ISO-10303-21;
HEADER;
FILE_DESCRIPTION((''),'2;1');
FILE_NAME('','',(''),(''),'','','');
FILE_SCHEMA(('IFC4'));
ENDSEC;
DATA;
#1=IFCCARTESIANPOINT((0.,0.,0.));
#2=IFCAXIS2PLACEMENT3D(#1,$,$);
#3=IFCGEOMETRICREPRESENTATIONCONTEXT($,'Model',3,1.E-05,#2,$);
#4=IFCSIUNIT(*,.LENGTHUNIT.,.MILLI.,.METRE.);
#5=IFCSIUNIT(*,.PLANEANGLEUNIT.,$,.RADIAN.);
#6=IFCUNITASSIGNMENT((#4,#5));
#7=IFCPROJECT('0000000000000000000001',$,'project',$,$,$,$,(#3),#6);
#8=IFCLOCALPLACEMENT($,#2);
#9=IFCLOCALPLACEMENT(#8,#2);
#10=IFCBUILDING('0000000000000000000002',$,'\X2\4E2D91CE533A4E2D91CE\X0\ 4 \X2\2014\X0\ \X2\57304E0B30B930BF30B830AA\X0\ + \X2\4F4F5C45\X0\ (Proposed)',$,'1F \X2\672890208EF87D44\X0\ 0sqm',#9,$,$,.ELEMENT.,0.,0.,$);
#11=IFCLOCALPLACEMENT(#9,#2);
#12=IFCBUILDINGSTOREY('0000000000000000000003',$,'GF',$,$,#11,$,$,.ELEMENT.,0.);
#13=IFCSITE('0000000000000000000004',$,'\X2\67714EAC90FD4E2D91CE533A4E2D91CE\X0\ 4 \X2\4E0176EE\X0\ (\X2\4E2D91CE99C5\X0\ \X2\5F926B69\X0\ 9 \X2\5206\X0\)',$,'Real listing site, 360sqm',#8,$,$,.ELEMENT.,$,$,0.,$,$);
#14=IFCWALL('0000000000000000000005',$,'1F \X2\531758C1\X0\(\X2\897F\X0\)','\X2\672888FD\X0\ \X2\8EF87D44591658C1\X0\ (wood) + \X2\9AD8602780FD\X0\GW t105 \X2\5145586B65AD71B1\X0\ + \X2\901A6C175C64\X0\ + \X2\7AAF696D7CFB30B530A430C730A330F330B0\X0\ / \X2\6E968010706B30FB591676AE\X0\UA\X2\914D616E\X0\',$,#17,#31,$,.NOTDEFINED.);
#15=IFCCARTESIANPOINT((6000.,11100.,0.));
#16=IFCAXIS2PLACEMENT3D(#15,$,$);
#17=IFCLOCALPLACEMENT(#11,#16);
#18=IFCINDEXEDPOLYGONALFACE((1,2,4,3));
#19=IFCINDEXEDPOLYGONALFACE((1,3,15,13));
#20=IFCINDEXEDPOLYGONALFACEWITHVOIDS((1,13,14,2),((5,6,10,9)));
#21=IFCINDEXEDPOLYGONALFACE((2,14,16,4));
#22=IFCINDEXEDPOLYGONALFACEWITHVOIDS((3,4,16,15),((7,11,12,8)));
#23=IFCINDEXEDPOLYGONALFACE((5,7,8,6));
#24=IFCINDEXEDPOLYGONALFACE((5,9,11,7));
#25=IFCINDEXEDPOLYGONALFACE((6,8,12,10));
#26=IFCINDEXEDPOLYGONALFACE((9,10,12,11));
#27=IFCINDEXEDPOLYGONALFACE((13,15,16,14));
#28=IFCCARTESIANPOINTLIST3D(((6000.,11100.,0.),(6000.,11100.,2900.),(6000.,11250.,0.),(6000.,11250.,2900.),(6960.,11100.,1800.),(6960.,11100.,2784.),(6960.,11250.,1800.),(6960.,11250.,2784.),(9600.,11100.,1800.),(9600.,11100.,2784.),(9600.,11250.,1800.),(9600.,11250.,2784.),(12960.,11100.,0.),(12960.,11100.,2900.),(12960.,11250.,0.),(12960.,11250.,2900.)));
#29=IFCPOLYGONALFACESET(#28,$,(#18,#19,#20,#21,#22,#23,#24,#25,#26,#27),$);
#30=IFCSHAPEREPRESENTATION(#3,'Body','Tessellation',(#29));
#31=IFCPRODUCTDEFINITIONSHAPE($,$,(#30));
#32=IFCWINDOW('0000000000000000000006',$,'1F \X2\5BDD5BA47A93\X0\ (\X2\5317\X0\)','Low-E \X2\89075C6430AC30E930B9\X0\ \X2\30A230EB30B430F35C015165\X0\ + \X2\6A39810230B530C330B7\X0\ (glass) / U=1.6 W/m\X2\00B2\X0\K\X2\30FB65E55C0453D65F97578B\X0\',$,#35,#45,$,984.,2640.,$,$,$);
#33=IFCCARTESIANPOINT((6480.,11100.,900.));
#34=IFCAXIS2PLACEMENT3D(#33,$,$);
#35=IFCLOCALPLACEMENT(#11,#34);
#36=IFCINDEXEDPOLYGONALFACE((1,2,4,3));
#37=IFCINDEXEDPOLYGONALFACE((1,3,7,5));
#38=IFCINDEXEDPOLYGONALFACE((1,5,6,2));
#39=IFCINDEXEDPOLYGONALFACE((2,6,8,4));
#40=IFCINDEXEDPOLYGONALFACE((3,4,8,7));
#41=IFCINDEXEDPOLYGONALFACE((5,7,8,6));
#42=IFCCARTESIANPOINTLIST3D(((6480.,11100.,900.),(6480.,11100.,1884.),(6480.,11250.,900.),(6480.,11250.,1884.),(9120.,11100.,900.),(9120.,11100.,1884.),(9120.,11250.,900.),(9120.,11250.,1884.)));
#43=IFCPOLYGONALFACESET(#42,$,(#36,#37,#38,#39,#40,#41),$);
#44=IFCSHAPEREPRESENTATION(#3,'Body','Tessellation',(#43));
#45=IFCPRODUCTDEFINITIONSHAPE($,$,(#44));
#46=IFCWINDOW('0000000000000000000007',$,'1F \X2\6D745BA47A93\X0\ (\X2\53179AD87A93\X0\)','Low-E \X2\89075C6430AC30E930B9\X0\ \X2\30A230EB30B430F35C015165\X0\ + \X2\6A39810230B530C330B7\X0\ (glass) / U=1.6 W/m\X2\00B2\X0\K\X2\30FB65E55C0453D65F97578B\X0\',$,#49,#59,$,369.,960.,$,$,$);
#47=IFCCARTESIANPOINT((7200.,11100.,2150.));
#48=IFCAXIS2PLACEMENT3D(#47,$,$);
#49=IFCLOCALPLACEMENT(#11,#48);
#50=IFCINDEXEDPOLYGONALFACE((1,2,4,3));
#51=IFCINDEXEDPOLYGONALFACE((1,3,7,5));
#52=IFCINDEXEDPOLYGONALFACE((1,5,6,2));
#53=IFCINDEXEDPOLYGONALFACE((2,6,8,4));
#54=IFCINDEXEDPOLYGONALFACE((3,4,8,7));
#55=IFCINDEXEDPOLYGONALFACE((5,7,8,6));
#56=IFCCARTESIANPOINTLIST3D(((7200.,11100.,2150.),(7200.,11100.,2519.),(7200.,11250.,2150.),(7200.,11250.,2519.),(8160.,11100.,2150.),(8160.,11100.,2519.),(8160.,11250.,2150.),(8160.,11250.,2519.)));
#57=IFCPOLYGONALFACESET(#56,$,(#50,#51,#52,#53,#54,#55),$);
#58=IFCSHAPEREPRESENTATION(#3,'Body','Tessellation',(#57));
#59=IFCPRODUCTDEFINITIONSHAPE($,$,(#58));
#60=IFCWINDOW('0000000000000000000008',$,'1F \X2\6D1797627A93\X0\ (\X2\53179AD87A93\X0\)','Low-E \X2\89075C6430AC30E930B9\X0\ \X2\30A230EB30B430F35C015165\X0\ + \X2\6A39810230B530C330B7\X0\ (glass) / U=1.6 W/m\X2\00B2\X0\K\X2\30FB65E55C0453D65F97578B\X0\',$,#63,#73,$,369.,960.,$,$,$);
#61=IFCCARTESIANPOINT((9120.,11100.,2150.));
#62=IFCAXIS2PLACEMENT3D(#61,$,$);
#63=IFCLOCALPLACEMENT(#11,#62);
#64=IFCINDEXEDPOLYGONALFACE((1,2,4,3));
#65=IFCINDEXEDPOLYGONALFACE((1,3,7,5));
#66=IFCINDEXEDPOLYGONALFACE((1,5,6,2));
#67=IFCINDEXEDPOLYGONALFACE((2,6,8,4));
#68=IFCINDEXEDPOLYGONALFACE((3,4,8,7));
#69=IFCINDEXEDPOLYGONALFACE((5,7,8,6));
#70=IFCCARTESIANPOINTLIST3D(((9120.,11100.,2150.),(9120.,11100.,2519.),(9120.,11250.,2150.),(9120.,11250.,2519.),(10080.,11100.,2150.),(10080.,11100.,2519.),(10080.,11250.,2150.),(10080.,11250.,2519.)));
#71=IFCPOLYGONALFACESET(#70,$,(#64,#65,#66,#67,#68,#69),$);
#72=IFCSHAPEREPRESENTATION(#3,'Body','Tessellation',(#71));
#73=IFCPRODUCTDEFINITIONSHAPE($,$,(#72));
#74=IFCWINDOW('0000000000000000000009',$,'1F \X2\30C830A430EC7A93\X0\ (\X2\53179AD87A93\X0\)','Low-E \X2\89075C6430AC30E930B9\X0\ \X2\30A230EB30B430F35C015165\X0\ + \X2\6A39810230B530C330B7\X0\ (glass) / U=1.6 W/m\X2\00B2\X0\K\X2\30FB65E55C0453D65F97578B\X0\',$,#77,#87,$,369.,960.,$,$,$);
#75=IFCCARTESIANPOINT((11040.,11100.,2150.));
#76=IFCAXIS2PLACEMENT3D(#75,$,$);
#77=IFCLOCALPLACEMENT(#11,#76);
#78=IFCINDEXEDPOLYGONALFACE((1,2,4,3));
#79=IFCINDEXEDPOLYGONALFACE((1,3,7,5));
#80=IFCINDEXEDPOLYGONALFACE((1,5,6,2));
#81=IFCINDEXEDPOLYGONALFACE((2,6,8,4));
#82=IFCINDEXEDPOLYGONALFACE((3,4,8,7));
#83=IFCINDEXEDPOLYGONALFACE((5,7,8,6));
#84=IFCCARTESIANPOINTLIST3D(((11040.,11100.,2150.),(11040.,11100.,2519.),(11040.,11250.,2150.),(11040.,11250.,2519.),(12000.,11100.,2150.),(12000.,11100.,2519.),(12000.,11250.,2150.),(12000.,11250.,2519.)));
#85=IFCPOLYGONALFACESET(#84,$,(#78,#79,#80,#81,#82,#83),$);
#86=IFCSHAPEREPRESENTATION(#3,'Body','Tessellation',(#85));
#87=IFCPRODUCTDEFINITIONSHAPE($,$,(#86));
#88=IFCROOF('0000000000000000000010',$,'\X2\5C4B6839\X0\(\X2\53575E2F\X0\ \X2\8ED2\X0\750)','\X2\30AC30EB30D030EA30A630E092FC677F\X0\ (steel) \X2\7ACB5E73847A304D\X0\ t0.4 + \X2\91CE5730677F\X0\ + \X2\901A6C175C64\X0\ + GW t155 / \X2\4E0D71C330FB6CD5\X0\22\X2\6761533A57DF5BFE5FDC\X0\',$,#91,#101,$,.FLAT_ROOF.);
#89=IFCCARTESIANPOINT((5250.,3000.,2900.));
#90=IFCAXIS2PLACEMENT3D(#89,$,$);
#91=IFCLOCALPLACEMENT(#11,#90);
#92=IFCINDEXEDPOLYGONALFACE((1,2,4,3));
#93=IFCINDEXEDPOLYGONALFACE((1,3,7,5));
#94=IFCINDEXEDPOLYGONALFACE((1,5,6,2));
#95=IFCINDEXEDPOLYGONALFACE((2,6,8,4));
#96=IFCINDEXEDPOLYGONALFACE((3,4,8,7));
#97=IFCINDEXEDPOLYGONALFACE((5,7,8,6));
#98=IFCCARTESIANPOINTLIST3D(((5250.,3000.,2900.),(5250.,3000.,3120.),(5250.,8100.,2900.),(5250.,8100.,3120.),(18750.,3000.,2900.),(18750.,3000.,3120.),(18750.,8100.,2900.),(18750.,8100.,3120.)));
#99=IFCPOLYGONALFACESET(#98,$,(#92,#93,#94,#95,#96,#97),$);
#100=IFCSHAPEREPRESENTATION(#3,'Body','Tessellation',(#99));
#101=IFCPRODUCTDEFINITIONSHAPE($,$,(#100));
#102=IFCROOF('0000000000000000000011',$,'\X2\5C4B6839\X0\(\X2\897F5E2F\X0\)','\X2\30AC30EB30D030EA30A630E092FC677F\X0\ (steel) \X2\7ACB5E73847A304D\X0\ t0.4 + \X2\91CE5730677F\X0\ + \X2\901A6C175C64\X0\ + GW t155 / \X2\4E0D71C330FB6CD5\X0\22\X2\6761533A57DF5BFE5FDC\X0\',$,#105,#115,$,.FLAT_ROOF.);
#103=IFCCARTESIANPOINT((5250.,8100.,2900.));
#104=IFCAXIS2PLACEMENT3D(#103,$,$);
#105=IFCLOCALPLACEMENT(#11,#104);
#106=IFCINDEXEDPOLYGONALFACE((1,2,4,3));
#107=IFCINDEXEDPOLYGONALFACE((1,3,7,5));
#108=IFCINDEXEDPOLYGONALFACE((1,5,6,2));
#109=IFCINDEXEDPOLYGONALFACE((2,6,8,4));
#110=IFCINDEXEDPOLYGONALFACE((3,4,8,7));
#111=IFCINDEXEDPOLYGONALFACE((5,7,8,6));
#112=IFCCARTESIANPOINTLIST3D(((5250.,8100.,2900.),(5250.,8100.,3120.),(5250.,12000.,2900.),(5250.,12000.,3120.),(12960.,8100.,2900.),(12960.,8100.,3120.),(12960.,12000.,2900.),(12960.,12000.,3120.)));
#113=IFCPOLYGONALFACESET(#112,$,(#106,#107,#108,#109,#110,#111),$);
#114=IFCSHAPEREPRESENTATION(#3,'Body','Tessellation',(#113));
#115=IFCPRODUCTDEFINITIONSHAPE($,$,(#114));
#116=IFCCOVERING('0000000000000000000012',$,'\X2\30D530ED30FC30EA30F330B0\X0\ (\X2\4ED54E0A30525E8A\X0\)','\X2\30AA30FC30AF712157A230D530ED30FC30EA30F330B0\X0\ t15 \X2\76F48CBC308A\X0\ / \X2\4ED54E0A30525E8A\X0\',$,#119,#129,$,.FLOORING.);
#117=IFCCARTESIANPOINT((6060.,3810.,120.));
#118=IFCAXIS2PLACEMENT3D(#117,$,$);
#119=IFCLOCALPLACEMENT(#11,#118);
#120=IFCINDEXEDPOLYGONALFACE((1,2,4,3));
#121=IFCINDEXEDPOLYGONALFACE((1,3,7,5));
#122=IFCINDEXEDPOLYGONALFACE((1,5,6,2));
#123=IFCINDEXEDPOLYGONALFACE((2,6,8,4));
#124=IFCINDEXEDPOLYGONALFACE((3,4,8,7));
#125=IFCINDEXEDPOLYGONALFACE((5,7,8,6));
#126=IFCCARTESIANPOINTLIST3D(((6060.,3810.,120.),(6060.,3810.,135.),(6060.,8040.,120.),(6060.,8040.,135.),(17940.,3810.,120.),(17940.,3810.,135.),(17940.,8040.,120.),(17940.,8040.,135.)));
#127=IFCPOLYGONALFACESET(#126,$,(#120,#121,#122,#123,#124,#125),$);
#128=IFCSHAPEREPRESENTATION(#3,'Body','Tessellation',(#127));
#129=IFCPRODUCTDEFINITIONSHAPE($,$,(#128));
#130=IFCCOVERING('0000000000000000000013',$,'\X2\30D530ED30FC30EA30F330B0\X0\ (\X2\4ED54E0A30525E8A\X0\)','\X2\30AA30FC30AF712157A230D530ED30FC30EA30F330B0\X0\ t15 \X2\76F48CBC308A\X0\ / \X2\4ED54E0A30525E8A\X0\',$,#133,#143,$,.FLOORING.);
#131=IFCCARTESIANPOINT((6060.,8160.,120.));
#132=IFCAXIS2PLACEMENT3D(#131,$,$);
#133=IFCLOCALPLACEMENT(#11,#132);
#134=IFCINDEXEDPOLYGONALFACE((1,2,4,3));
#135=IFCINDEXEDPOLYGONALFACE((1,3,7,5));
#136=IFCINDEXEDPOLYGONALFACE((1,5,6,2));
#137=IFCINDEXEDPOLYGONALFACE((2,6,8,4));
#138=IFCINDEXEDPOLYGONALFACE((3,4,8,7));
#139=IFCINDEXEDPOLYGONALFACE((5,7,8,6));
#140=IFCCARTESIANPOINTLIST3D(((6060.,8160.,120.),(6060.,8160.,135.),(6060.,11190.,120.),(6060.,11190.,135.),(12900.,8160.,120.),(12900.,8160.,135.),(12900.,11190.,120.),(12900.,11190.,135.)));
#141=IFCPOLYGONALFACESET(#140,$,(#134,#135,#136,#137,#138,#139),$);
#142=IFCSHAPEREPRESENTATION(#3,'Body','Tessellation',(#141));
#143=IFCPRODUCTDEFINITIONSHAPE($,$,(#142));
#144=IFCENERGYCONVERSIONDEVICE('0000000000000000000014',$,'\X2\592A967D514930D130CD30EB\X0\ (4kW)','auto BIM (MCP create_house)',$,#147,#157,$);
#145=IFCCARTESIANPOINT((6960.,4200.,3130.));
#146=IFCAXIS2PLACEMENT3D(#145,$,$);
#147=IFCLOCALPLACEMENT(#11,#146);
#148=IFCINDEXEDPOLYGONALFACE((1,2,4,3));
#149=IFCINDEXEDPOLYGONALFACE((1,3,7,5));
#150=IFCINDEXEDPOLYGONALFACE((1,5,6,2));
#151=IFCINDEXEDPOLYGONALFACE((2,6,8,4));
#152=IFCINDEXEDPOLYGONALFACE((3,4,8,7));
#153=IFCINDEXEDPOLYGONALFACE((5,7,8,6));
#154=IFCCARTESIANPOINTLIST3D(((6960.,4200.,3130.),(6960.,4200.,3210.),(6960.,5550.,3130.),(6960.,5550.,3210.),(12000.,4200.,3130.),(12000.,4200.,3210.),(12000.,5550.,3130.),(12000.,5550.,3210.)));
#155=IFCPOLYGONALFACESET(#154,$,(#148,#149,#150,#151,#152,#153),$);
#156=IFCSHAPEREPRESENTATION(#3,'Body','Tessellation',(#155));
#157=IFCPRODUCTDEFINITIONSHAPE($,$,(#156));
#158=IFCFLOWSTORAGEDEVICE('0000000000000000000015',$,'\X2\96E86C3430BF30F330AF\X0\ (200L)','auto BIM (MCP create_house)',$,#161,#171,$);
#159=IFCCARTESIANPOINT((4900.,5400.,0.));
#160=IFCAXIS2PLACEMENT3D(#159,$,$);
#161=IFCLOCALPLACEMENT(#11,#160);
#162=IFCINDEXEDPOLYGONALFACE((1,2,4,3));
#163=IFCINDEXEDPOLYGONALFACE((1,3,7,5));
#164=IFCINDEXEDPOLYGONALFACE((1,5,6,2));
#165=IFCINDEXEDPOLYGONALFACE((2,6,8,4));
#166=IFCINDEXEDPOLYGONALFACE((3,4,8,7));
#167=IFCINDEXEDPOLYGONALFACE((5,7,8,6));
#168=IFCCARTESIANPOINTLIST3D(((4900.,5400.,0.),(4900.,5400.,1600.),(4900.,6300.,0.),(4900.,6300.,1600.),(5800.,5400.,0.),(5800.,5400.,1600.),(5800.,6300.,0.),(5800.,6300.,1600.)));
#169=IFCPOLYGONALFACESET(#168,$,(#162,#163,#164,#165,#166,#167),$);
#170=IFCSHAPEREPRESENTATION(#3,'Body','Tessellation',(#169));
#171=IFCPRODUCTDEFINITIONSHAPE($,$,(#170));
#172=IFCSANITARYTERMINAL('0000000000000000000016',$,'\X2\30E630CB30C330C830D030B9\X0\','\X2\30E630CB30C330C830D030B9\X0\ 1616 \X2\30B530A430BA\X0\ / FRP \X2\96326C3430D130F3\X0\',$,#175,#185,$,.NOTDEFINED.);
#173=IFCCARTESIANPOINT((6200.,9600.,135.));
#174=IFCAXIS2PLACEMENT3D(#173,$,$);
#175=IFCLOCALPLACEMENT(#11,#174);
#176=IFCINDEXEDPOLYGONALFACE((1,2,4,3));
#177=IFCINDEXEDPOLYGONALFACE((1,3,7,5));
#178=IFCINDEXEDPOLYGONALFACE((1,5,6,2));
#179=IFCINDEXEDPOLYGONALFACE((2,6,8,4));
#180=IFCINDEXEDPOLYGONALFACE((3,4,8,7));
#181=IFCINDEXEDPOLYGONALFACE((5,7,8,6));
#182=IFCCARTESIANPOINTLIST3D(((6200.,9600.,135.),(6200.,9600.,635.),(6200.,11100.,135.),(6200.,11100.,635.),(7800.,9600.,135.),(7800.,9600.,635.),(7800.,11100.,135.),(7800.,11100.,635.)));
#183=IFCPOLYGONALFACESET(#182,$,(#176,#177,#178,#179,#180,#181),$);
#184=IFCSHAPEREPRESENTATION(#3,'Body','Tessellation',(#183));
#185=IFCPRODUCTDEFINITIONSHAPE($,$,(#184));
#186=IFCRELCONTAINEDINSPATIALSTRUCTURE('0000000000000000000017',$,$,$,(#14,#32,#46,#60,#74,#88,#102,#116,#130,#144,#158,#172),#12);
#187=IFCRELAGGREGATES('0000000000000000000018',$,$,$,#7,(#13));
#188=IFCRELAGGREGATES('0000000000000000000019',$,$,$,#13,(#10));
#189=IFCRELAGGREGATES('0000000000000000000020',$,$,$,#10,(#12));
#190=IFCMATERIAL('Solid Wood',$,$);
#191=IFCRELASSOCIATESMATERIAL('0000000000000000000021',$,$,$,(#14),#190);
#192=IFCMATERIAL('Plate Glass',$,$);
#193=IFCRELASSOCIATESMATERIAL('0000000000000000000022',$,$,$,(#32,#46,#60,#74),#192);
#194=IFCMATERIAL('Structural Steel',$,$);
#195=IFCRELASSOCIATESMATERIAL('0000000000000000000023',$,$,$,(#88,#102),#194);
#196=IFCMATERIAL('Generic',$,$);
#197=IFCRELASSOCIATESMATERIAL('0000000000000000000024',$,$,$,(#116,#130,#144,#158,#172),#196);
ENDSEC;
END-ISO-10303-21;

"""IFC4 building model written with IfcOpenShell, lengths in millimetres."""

from ifc_helpers import new_model, si_unit, frame, frame_2d, origin, place, context, project, spatial, rectangle, extrude, material, element, fill, save


model = new_model("IFC4")

# Units and contexts
model_context = context("Model", 3, precision=1e-05, world=origin())
ifc_project = project(units=[si_unit("LENGTHUNIT", "METRE", prefix="MILLI"), si_unit("PLANEANGLEUNIT", "RADIAN")], contexts=[model_context])

# Site, building, storey
site_placement = place(None, origin())
site = spatial("IfcSite", under=ifc_project, at=site_placement, Name="東京都中野区中野 4 丁目 (中野駅 徒歩 9 分)", ObjectType="Real listing site, 360sqm", CompositionType="ELEMENT", RefElevation=0.0)
building_placement = place(site_placement, origin())
building = spatial("IfcBuilding", under=site, at=building_placement, Name="中野区中野 4 — 地下スタジオ + 住居 (Proposed)", ObjectType="1F 木造軸組 0sqm", CompositionType="ELEMENT", ElevationOfRefHeight=0.0, ElevationOfTerrain=0.0)
storey_placement = place(building_placement, origin())
storey = spatial("IfcBuildingStorey", under=building, at=storey_placement, Name="GF", CompositionType="ELEMENT", Elevation=0.0)

# Shared definitions
ifc_material_1 = material(Name="Solid Wood")

# Shared definitions
ifc_material_2 = material(Name="Plate Glass")

# Wall, openings, windows
wall_1_placement = place(storey_placement, frame((6000.0, 11100.0, 0.0)))
wall_1 = element("IfcWall", 1, at=wall_1_placement, inside=storey, material=ifc_material_1, Name="1F 北壁(西)", Description="木製 軸組外壁 (wood) + 高性能GW t105 充填断熱 + 通気層 + 窯業系サイディング / 準耐火・外皮UA配慮", PredefinedType="NOTDEFINED", context=model_context, shape_type="SweptSolid", body=[
    extrude(rectangle(XDim=6960.0, YDim=150.0, at=frame_2d((3480.0, 75.0))), frame((6000.0, 11100.0, 0.0)), (0.0, 0.0, 1.0), 2900.0),
])
opening_1_placement = place(storey_placement, frame((6480.0, 11100.0, 900.0)))
opening_1 = element("IfcOpeningElement", 2, at=opening_1_placement, cuts=wall_1, PredefinedType="NOTDEFINED", context=model_context, shape_type="SweptSolid", body=[
    extrude(rectangle(XDim=2640.0, YDim=150.0, at=frame_2d((1320.0, 75.0))), frame((6480.0, 11100.0, 900.0)), (0.0, 0.0, 1.0), 984.0),
])
opening_2_placement = place(storey_placement, frame((7200.0, 11100.0, 2150.0)))
opening_2 = element("IfcOpeningElement", 3, at=opening_2_placement, cuts=wall_1, PredefinedType="NOTDEFINED", context=model_context, shape_type="SweptSolid", body=[
    extrude(rectangle(XDim=960.0, YDim=150.0, at=frame_2d((480.0, 75.0))), frame((7200.0, 11100.0, 2150.0)), (0.0, 0.0, 1.0), 369.0),
])
opening_3_placement = place(storey_placement, frame((9120.0, 11100.0, 2150.0)))
opening_3 = element("IfcOpeningElement", 4, at=opening_3_placement, cuts=wall_1, PredefinedType="NOTDEFINED", context=model_context, shape_type="SweptSolid", body=[
    extrude(rectangle(XDim=960.0, YDim=150.0, at=frame_2d((480.0, 75.0))), frame((9120.0, 11100.0, 2150.0)), (0.0, 0.0, 1.0), 369.0),
])
opening_4_placement = place(storey_placement, frame((11040.0, 11100.0, 2150.0)))
opening_4 = element("IfcOpeningElement", 5, at=opening_4_placement, cuts=wall_1, PredefinedType="NOTDEFINED", context=model_context, shape_type="SweptSolid", body=[
    extrude(rectangle(XDim=960.0, YDim=150.0, at=frame_2d((480.0, 75.0))), frame((11040.0, 11100.0, 2150.0)), (0.0, 0.0, 1.0), 369.0),
])
window_1_placement = place(storey_placement, frame((6480.0, 11100.0, 900.0)))
window_1 = element("IfcWindow", 6, at=window_1_placement, inside=storey, material=ifc_material_2, Name="1F 寝室窓 (北)", Description="Low-E 複層ガラス アルゴン封入 + 樹脂サッシ (glass) / U=1.6 W/m²K・日射取得型", OverallHeight=984.0, OverallWidth=2640.0, context=model_context, shape_type="SweptSolid", body=[
    extrude(rectangle(XDim=2640.0, YDim=150.0, at=frame_2d((1320.0, 75.0))), frame((6480.0, 11100.0, 900.0)), (0.0, 0.0, 1.0), 984.0),
])
fill(opening_1, window_1)
window_2_placement = place(storey_placement, frame((7200.0, 11100.0, 2150.0)))
window_2 = element("IfcWindow", 7, at=window_2_placement, inside=storey, material=ifc_material_2, Name="1F 浴室窓 (北高窓)", Description="Low-E 複層ガラス アルゴン封入 + 樹脂サッシ (glass) / U=1.6 W/m²K・日射取得型", OverallHeight=369.0, OverallWidth=960.0, context=model_context, shape_type="SweptSolid", body=[
    extrude(rectangle(XDim=960.0, YDim=150.0, at=frame_2d((480.0, 75.0))), frame((7200.0, 11100.0, 2150.0)), (0.0, 0.0, 1.0), 369.0),
])
fill(opening_2, window_2)
window_3_placement = place(storey_placement, frame((9120.0, 11100.0, 2150.0)))
window_3 = element("IfcWindow", 8, at=window_3_placement, inside=storey, material=ifc_material_2, Name="1F 洗面窓 (北高窓)", Description="Low-E 複層ガラス アルゴン封入 + 樹脂サッシ (glass) / U=1.6 W/m²K・日射取得型", OverallHeight=369.0, OverallWidth=960.0, context=model_context, shape_type="SweptSolid", body=[
    extrude(rectangle(XDim=960.0, YDim=150.0, at=frame_2d((480.0, 75.0))), frame((9120.0, 11100.0, 2150.0)), (0.0, 0.0, 1.0), 369.0),
])
fill(opening_3, window_3)
window_4_placement = place(storey_placement, frame((11040.0, 11100.0, 2150.0)))
window_4 = element("IfcWindow", 9, at=window_4_placement, inside=storey, material=ifc_material_2, Name="1F トイレ窓 (北高窓)", Description="Low-E 複層ガラス アルゴン封入 + 樹脂サッシ (glass) / U=1.6 W/m²K・日射取得型", OverallHeight=369.0, OverallWidth=960.0, context=model_context, shape_type="SweptSolid", body=[
    extrude(rectangle(XDim=960.0, YDim=150.0, at=frame_2d((480.0, 75.0))), frame((11040.0, 11100.0, 2150.0)), (0.0, 0.0, 1.0), 369.0),
])
fill(opening_4, window_4)

# Roofs
ifc_material_3 = material(Name="Structural Steel")
roof_1_placement = place(storey_placement, frame((5250.0, 3000.0, 2900.0)))
element("IfcRoof", 10, at=roof_1_placement, inside=storey, material=ifc_material_3, Name="屋根(南帯 軒750)", Description="ガルバリウム鋼板 (steel) 立平葺き t0.4 + 野地板 + 通気層 + GW t155 / 不燃・法22条区域対応", PredefinedType="FLAT_ROOF", context=model_context, shape_type="SweptSolid", body=[
    extrude(rectangle(XDim=13500.0, YDim=5100.0, at=frame_2d((6750.0, 2550.0))), frame((5250.0, 3000.0, 2900.0)), (0.0, 0.0, 1.0), 220.0),
])
roof_2_placement = place(storey_placement, frame((5250.0, 8100.0, 2900.0)))
element("IfcRoof", 11, at=roof_2_placement, inside=storey, material=ifc_material_3, Name="屋根(西帯)", Description="ガルバリウム鋼板 (steel) 立平葺き t0.4 + 野地板 + 通気層 + GW t155 / 不燃・法22条区域対応", PredefinedType="FLAT_ROOF", context=model_context, shape_type="SweptSolid", body=[
    extrude(rectangle(XDim=7710.0, YDim=3900.0, at=frame_2d((3855.0, 1950.0))), frame((5250.0, 8100.0, 2900.0)), (0.0, 0.0, 1.0), 220.0),
])

# Coverings
ifc_material_4 = material(Name="Generic")
covering_1_placement = place(storey_placement, frame((6060.0, 3810.0, 120.0)))
element("IfcCovering", 12, at=covering_1_placement, inside=storey, material=ifc_material_4, Name="フローリング (仕上げ床)", Description="オーク無垢フローリング t15 直貼り / 仕上げ床", PredefinedType="FLOORING", context=model_context, shape_type="SweptSolid", body=[
    extrude(rectangle(XDim=11880.0, YDim=4230.0, at=frame_2d((5940.0, 2115.0))), frame((6060.0, 3810.0, 120.0)), (0.0, 0.0, 1.0), 15.0),
])
covering_2_placement = place(storey_placement, frame((6060.0, 8160.0, 120.0)))
element("IfcCovering", 13, at=covering_2_placement, inside=storey, material=ifc_material_4, Name="フローリング (仕上げ床)", Description="オーク無垢フローリング t15 直貼り / 仕上げ床", PredefinedType="FLOORING", context=model_context, shape_type="SweptSolid", body=[
    extrude(rectangle(XDim=6840.0, YDim=3030.0, at=frame_2d((3420.0, 1515.0))), frame((6060.0, 8160.0, 120.0)), (0.0, 0.0, 1.0), 15.0),
])

# Energy conversion device
energy_conversion_device_placement = place(storey_placement, frame((6960.0, 4200.0, 3130.0)))
element("IfcEnergyConversionDevice", 14, at=energy_conversion_device_placement, inside=storey, material=ifc_material_4, Name="太陽光パネル (4kW)", Description="auto BIM (MCP create_house)", context=model_context, shape_type="SweptSolid", body=[
    extrude(rectangle(XDim=5040.0, YDim=1350.0, at=frame_2d((2520.0, 675.0))), frame((6960.0, 4200.0, 3130.0)), (0.0, 0.0, 1.0), 80.0),
])

# Flow storage device
flow_storage_device_placement = place(storey_placement, frame((4900.0, 5400.0, 0.0)))
element("IfcFlowStorageDevice", 15, at=flow_storage_device_placement, inside=storey, material=ifc_material_4, Name="雨水タンク (200L)", Description="auto BIM (MCP create_house)", context=model_context, shape_type="SweptSolid", body=[
    extrude(rectangle(XDim=900.0, YDim=900.0, at=frame_2d((450.0, 450.0))), frame((4900.0, 5400.0, 0.0)), (0.0, 0.0, 1.0), 1600.0),
])

# Sanitary terminal
sanitary_terminal_placement = place(storey_placement, frame((6200.0, 9600.0, 135.0)))
element("IfcSanitaryTerminal", 16, at=sanitary_terminal_placement, inside=storey, material=ifc_material_4, Name="ユニットバス", Description="ユニットバス 1616 サイズ / FRP 防水パン", PredefinedType="NOTDEFINED", context=model_context, shape_type="SweptSolid", body=[
    extrude(rectangle(XDim=1600.0, YDim=1500.0, at=frame_2d((800.0, 750.0))), frame((6200.0, 9600.0, 135.0)), (0.0, 0.0, 1.0), 500.0),
])

save(model, "model.ifc")
